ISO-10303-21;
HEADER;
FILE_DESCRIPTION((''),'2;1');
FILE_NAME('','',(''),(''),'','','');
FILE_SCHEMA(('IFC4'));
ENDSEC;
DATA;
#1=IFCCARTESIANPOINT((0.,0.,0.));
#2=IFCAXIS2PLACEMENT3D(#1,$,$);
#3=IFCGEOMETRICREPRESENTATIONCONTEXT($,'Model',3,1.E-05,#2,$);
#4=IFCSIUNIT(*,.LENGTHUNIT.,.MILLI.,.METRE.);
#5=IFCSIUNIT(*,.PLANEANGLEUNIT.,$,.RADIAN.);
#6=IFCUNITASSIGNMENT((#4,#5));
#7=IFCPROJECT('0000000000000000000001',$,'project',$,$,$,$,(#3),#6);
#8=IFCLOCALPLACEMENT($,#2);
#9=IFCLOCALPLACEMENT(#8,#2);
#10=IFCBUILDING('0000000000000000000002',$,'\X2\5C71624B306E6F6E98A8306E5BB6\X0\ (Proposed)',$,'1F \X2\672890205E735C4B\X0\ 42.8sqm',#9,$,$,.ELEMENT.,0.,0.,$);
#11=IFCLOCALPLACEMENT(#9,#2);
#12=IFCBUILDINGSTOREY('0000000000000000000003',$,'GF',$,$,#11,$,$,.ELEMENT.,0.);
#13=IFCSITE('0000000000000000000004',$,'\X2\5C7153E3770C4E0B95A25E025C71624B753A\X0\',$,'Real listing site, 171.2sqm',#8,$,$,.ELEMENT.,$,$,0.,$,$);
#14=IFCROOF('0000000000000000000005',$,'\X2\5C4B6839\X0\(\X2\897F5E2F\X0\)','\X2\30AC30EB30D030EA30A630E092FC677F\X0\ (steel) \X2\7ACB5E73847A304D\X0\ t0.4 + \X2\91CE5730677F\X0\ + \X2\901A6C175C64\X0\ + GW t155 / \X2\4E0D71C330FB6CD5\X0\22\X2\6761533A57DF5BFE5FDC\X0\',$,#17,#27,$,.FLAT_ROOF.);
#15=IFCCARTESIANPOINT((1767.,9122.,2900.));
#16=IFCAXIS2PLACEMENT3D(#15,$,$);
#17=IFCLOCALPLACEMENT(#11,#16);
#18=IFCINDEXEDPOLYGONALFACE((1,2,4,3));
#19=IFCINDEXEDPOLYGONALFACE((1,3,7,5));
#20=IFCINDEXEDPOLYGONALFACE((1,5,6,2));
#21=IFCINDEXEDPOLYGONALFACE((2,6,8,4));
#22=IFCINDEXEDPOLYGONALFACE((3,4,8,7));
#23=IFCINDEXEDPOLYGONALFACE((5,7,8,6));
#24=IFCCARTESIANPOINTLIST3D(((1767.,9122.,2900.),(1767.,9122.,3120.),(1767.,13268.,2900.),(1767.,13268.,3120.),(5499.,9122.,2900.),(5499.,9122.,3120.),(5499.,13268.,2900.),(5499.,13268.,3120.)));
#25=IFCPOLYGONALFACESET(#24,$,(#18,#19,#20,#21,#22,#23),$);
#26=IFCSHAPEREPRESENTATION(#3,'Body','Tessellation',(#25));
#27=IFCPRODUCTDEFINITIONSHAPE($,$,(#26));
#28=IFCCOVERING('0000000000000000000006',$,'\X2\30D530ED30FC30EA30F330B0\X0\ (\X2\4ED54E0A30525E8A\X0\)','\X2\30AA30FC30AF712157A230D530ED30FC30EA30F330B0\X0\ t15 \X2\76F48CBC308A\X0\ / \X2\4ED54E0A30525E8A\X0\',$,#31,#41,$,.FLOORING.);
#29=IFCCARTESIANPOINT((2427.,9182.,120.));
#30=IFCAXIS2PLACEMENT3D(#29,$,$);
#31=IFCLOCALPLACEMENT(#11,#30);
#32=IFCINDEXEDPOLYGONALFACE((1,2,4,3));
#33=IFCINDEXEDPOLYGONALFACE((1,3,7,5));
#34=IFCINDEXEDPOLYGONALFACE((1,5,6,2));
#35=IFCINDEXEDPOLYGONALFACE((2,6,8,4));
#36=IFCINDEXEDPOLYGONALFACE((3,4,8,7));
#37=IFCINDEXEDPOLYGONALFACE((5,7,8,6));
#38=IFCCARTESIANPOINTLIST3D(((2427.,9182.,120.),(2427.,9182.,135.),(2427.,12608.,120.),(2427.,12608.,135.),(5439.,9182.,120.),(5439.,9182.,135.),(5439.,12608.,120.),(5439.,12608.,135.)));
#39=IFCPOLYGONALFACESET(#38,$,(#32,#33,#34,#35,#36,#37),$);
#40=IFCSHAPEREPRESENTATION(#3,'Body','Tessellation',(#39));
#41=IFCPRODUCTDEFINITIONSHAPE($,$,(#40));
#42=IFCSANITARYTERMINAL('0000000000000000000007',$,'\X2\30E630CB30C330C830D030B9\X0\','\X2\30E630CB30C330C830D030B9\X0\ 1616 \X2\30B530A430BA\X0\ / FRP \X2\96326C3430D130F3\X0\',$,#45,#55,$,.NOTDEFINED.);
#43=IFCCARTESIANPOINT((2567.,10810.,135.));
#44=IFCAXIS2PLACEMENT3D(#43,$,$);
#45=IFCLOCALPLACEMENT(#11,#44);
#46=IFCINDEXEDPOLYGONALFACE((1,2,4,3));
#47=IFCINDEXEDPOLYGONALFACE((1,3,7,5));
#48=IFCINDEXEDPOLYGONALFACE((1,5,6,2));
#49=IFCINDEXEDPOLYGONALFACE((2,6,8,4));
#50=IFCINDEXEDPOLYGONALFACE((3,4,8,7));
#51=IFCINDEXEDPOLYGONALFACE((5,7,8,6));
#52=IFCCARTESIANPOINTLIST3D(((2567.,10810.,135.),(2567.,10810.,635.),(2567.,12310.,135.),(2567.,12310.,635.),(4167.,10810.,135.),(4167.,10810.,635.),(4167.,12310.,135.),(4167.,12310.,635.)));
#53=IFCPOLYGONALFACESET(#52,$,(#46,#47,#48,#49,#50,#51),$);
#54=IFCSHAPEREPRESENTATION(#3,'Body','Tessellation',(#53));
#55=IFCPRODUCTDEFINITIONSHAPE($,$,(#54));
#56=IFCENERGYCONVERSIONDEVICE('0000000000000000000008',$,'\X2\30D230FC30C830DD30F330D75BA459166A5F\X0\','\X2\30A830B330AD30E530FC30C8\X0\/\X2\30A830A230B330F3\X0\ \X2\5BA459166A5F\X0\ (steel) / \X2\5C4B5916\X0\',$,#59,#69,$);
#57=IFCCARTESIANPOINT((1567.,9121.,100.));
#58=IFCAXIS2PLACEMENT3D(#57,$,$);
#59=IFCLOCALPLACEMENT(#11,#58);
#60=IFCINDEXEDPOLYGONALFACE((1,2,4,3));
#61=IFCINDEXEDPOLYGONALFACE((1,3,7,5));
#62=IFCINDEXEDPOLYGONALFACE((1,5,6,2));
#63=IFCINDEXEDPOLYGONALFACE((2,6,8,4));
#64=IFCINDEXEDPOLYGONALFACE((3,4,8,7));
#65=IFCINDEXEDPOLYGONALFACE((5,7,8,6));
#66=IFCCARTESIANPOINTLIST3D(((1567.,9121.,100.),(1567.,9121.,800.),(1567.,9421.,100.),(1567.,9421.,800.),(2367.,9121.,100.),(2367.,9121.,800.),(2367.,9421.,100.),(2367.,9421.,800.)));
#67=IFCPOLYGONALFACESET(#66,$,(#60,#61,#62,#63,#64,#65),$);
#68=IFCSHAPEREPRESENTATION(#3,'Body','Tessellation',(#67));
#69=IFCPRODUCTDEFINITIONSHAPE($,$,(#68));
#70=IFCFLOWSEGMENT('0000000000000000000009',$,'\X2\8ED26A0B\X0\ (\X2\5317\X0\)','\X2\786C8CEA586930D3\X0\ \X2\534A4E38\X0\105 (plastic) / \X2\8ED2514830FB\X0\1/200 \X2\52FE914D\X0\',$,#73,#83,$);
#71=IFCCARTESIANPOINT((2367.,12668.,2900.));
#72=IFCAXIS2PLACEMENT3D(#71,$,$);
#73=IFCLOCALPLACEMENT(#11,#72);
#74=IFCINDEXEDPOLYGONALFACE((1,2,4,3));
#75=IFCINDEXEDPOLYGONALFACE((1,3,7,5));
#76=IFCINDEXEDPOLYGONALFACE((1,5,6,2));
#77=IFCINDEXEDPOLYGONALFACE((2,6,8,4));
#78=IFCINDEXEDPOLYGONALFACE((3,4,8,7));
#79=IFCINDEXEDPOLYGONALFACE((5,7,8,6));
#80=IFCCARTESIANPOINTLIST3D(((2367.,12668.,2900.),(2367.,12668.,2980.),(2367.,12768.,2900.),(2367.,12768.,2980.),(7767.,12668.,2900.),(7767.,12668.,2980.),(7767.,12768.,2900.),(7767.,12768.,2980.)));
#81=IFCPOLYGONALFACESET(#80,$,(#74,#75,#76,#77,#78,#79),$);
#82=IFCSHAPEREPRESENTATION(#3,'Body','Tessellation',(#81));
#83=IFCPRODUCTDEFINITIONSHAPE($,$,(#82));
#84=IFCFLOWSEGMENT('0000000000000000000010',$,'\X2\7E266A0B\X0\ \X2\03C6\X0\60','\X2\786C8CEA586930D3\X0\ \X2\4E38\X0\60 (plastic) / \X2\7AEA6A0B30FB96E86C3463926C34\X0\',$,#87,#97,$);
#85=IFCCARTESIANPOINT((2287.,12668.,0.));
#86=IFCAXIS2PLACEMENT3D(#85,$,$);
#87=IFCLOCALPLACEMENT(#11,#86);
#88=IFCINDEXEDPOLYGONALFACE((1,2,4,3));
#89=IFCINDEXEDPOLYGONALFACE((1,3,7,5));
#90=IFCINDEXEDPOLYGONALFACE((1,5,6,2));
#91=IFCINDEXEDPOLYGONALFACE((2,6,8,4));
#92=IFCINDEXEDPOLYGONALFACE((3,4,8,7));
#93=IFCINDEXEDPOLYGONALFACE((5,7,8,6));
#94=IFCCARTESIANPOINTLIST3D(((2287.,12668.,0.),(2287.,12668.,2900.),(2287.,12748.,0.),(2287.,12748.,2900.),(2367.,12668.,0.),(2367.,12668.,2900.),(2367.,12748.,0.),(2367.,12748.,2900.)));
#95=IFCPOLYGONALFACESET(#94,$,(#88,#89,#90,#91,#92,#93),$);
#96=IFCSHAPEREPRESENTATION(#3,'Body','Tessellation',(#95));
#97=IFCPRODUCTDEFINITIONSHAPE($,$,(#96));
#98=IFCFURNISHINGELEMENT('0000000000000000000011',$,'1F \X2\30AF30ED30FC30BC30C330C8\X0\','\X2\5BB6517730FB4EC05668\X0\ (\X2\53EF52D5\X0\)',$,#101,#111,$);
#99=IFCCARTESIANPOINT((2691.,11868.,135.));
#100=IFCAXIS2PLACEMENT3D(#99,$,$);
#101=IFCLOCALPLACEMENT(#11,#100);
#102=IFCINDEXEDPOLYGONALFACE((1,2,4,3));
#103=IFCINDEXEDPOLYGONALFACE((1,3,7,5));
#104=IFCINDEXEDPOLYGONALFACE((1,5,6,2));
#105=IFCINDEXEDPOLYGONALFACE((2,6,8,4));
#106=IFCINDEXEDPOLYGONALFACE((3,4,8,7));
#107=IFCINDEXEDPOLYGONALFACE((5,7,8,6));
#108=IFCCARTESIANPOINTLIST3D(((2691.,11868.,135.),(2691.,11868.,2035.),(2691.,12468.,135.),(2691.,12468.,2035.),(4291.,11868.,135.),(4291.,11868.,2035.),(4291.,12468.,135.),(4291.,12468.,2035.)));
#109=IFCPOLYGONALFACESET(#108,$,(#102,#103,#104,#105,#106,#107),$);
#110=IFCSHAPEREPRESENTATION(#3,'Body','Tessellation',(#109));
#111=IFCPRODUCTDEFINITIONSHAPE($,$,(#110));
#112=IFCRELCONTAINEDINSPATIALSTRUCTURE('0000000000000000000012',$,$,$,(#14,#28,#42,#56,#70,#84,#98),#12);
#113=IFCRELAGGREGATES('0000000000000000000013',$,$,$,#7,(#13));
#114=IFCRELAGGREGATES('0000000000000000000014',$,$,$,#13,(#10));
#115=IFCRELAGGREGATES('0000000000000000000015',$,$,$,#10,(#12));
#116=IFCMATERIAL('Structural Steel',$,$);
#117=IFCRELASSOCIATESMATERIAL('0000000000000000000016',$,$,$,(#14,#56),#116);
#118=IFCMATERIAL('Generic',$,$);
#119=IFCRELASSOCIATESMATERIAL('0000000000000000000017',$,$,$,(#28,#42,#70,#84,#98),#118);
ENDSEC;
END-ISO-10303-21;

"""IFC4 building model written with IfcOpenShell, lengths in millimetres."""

from ifc_helpers import new_model, si_unit, frame, frame_2d, origin, place, context, project, spatial, rectangle, extrude, material, element, save


model = new_model("IFC4")

# Units and contexts
model_context = context("Model", 3, precision=1e-05, world=origin())
ifc_project = project(units=[si_unit("LENGTHUNIT", "METRE", prefix="MILLI"), si_unit("PLANEANGLEUNIT", "RADIAN")], contexts=[model_context])

# Site, building, storey
site_placement = place(None, origin())
site = spatial("IfcSite", under=ifc_project, at=site_placement, Name="山口県下関市山手町", ObjectType="Real listing site, 171.2sqm", CompositionType="ELEMENT", RefElevation=0.0)
building_placement = place(site_placement, origin())
building = spatial("IfcBuilding", under=site, at=building_placement, Name="山手の潮風の家 (Proposed)", ObjectType="1F 木造平屋 42.8sqm", CompositionType="ELEMENT", ElevationOfRefHeight=0.0, ElevationOfTerrain=0.0)
storey_placement = place(building_placement, origin())
storey = spatial("IfcBuildingStorey", under=building, at=storey_placement, Name="GF", CompositionType="ELEMENT", Elevation=0.0)

# Roof
ifc_material_1 = material(Name="Structural Steel")
roof_placement = place(storey_placement, frame((1767.0, 9122.0, 2900.0)))
element("IfcRoof", 1, at=roof_placement, inside=storey, material=ifc_material_1, Name="屋根(西帯)", Description="ガルバリウム鋼板 (steel) 立平葺き t0.4 + 野地板 + 通気層 + GW t155 / 不燃・法22条区域対応", PredefinedType="FLAT_ROOF", context=model_context, shape_type="SweptSolid", body=[
    extrude(rectangle(XDim=3732.0, YDim=4146.0, at=frame_2d((1866.0, 2073.0))), frame((1767.0, 9122.0, 2900.0)), (0.0, 0.0, 1.0), 220.0),
])

# Covering
ifc_material_2 = material(Name="Generic")
covering_placement = place(storey_placement, frame((2427.0, 9182.0, 120.0)))
element("IfcCovering", 2, at=covering_placement, inside=storey, material=ifc_material_2, Name="フローリング (仕上げ床)", Description="オーク無垢フローリング t15 直貼り / 仕上げ床", PredefinedType="FLOORING", context=model_context, shape_type="SweptSolid", body=[
    extrude(rectangle(XDim=3012.0, YDim=3426.0, at=frame_2d((1506.0, 1713.0))), frame((2427.0, 9182.0, 120.0)), (0.0, 0.0, 1.0), 15.0),
])

# Sanitary terminal
sanitary_terminal_placement = place(storey_placement, frame((2567.0, 10810.0, 135.0)))
element("IfcSanitaryTerminal", 3, at=sanitary_terminal_placement, inside=storey, material=ifc_material_2, Name="ユニットバス", Description="ユニットバス 1616 サイズ / FRP 防水パン", PredefinedType="NOTDEFINED", context=model_context, shape_type="SweptSolid", body=[
    extrude(rectangle(XDim=1600.0, YDim=1500.0, at=frame_2d((800.0, 750.0))), frame((2567.0, 10810.0, 135.0)), (0.0, 0.0, 1.0), 500.0),
])

# Energy conversion device
energy_conversion_device_placement = place(storey_placement, frame((1567.0, 9121.0, 100.0)))
element("IfcEnergyConversionDevice", 4, at=energy_conversion_device_placement, inside=storey, material=ifc_material_1, Name="ヒートポンプ室外機", Description="エコキュート/エアコン 室外機 (steel) / 屋外", context=model_context, shape_type="SweptSolid", body=[
    extrude(rectangle(XDim=800.0, YDim=300.0, at=frame_2d((400.0, 150.0))), frame((1567.0, 9121.0, 100.0)), (0.0, 0.0, 1.0), 700.0),
])

# Flow segments
flow_segment_1_placement = place(storey_placement, frame((2367.0, 12668.0, 2900.0)))
element("IfcFlowSegment", 5, at=flow_segment_1_placement, inside=storey, material=ifc_material_2, Name="軒樋 (北)", Description="硬質塩ビ 半丸105 (plastic) / 軒先・1/200 勾配", context=model_context, shape_type="SweptSolid", body=[
    extrude(rectangle(XDim=5400.0, YDim=100.0, at=frame_2d((2700.0, 50.0))), frame((2367.0, 12668.0, 2900.0)), (0.0, 0.0, 1.0), 80.0),
])
flow_segment_2_placement = place(storey_placement, frame((2287.0, 12668.0, 0.0)))
element("IfcFlowSegment", 6, at=flow_segment_2_placement, inside=storey, material=ifc_material_2, Name="縦樋 φ60", Description="硬質塩ビ 丸60 (plastic) / 竪樋・雨水排水", context=model_context, shape_type="SweptSolid", body=[
    extrude(rectangle(XDim=80.0, YDim=80.0, at=frame_2d((40.0, 40.0))), frame((2287.0, 12668.0, 0.0)), (0.0, 0.0, 1.0), 2900.0),
])

# Furnishing element
furnishing_placement = place(storey_placement, frame((2691.0, 11868.0, 135.0)))
element("IfcFurnishingElement", 7, at=furnishing_placement, inside=storey, material=ifc_material_2, Name="1F クローゼット", Description="家具・什器 (可動)", context=model_context, shape_type="SweptSolid", body=[
    extrude(rectangle(XDim=1600.0, YDim=600.0, at=frame_2d((800.0, 300.0))), frame((2691.0, 11868.0, 135.0)), (0.0, 0.0, 1.0), 1900.0),
])

save(model, "model.ifc")
